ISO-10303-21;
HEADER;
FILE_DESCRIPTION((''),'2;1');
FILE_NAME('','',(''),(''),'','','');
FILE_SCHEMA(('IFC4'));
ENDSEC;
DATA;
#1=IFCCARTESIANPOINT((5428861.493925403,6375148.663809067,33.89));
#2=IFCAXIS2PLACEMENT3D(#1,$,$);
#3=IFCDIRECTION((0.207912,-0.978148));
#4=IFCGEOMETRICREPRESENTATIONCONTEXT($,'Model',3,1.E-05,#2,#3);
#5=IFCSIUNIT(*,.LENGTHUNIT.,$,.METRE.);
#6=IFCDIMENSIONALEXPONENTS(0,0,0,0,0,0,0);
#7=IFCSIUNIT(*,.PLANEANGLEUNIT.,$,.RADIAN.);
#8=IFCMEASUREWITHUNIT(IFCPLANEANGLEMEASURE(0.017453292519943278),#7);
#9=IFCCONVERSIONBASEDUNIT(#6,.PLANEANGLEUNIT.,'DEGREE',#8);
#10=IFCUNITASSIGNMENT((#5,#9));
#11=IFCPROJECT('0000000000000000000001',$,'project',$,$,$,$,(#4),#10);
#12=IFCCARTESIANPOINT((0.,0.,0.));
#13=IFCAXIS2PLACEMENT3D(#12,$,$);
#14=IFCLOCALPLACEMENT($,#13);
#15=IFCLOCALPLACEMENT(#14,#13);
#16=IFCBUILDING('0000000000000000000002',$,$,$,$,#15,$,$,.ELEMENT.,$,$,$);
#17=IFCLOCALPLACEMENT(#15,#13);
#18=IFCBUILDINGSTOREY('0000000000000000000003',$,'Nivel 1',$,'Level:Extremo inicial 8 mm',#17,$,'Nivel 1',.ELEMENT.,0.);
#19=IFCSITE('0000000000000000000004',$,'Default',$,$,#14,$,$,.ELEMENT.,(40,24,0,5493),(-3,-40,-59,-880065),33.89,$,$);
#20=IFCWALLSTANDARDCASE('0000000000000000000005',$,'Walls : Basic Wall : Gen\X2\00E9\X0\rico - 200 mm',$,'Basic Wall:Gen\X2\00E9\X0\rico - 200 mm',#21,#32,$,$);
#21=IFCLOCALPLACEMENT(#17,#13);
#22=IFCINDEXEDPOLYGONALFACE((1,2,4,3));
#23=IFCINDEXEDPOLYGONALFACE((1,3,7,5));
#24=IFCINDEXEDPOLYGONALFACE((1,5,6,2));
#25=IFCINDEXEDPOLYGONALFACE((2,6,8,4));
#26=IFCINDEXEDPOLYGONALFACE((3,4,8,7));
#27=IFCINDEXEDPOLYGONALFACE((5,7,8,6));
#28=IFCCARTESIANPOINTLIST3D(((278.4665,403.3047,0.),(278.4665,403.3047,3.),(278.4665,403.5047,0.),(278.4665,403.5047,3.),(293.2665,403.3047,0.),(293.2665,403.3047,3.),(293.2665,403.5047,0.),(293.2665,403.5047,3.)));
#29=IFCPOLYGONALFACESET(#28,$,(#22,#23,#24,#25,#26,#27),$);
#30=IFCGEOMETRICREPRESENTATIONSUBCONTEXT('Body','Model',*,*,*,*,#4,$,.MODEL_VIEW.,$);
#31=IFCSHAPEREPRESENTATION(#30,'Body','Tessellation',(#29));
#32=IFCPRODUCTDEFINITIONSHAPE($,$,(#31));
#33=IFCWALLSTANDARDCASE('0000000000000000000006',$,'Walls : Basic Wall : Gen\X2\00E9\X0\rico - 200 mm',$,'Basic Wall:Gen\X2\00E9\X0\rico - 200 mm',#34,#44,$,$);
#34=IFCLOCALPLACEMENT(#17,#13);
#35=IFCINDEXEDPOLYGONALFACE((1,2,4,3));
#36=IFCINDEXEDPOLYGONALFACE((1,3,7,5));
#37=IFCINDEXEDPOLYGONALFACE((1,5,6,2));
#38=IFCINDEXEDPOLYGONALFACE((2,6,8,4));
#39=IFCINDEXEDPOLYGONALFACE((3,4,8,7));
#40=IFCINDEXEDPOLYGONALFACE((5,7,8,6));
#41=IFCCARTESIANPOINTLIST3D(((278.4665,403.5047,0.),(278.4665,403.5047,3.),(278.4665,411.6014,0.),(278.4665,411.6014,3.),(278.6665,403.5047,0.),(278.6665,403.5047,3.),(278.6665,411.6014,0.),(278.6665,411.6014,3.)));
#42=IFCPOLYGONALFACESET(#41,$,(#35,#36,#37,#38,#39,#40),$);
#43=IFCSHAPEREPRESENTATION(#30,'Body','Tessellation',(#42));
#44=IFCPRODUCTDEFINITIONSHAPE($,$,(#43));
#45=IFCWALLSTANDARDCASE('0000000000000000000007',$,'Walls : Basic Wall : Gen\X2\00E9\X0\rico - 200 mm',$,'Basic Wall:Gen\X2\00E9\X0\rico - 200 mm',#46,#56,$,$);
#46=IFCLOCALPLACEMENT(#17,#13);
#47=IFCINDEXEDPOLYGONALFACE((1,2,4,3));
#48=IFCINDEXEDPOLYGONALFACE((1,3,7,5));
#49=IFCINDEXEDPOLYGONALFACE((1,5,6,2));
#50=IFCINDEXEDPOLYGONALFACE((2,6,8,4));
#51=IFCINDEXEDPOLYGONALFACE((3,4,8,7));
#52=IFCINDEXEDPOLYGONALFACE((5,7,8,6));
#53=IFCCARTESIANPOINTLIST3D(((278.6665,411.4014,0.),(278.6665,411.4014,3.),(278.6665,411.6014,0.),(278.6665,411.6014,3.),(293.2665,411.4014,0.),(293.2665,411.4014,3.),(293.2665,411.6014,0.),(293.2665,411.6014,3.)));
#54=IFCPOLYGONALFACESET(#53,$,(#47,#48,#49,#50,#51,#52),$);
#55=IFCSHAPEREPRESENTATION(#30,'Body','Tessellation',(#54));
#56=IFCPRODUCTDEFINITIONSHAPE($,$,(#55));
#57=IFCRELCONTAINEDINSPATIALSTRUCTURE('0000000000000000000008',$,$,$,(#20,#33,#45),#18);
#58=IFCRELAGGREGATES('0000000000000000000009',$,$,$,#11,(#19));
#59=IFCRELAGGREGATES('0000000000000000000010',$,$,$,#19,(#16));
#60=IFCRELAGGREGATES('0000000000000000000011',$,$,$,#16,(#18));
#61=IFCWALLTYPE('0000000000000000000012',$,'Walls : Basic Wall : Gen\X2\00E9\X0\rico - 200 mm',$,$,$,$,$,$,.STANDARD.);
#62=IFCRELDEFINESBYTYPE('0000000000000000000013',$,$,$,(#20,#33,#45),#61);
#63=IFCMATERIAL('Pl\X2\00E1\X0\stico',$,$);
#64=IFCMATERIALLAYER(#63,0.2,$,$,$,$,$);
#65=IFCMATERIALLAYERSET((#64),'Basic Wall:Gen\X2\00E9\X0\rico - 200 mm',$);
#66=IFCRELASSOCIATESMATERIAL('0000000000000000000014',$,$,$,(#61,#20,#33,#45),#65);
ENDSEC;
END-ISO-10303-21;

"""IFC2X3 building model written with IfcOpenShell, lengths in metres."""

from ifc_helpers import new_model, entity, si_unit, converted_unit, direction, frame, frame_2d, origin, place, context, subcontext, project, spatial, rectangle, extrude, material, layer, layer_set, layer_usage, type_object, element, save


model = new_model("IFC2X3")

# Units and contexts
model_context = context("Model", 3, precision=1e-05, world=frame((5428861.493925403, 6375148.663809067, 33.89)), true_north=direction((0.207912, -0.978148)))
body_context = subcontext(model_context, "Body", "Model", "MODEL_VIEW")
ifc_project = project(units=[si_unit("LENGTHUNIT", "METRE"), converted_unit("PLANEANGLEUNIT", "DEGREE", entity("IfcPlaneAngleMeasure", 0.017453292519943278), si_unit("PLANEANGLEUNIT", "RADIAN"), dimensions=[0, 0, 0, 0, 0, 0, 0])], contexts=[model_context])

# Site, building, storey
site_placement = place(None, origin())
site = spatial("IfcSite", under=ifc_project, at=site_placement, Name="Default", CompositionType="ELEMENT", RefLatitude=(40, 24, 0, 5493), RefLongitude=(-3, -40, -59, -880065), RefElevation=33.89)
building_placement = place(site_placement, origin())
building = spatial("IfcBuilding", under=site, at=building_placement, CompositionType="ELEMENT")
storey_placement = place(building_placement, origin())
storey = spatial("IfcBuildingStorey", under=building, at=storey_placement, Name="Nivel 1", ObjectType="Level:Extremo inicial 8 mm", LongName="Nivel 1", CompositionType="ELEMENT", Elevation=0.0)

# Walls
ifc_material_1 = material(Name="Plástico")
ifc_layer_1 = layer(ifc_material_1, 0.2)
ifc_layer_set_1 = layer_set([ifc_layer_1], Name="Basic Wall:Genérico - 200 mm")
wall_type = type_object("IfcWallType", Name="Walls : Basic Wall : Genérico - 200 mm", PredefinedType="STANDARD", material=ifc_layer_set_1)
ifc_layer_usage_1 = layer_usage(ifc_layer_set_1, "AXIS2", "NEGATIVE", 0.1)
wall_1_placement = place(storey_placement, frame((293.2665, 403.4047, 0.0), z_axis=(0.0, 0.0, 1.0), x_axis=(-1.0, 0.0, 0.0)))
element("IfcWallStandardCase", 1, at=wall_1_placement, inside=storey, type_object=wall_type, material=ifc_layer_usage_1, Name="Walls : Basic Wall : Genérico - 200 mm", ObjectType="Basic Wall:Genérico - 200 mm", context=body_context, shape_type="SweptSolid", body=[
    extrude(rectangle(XDim=14.8, YDim=0.2, at=frame_2d((7.4, 0.0), x_axis=(-1.0, 0.0))), origin(), (0.0, 0.0, 1.0), 3.0),
])
ifc_layer_usage_2 = layer_usage(ifc_layer_set_1, "AXIS2", "NEGATIVE", 0.1)
wall_2_placement = place(storey_placement, frame((278.5665, 403.5047, 0.0), z_axis=(0.0, 0.0, 1.0), x_axis=(0.0, 1.0, 0.0)))
element("IfcWallStandardCase", 2, at=wall_2_placement, inside=storey, type_object=wall_type, material=ifc_layer_usage_2, Name="Walls : Basic Wall : Genérico - 200 mm", ObjectType="Basic Wall:Genérico - 200 mm", context=body_context, shape_type="SweptSolid", body=[
    extrude(rectangle(XDim=8.0967, YDim=0.2, at=frame_2d((4.0484, 0.0), x_axis=(-1.0, 0.0))), origin(), (0.0, 0.0, 1.0), 3.0),
])
ifc_layer_usage_3 = layer_usage(ifc_layer_set_1, "AXIS2", "NEGATIVE", 0.1)
wall_3_placement = place(storey_placement, frame((278.6665, 411.5014, 0.0)))
element("IfcWallStandardCase", 3, at=wall_3_placement, inside=storey, type_object=wall_type, material=ifc_layer_usage_3, Name="Walls : Basic Wall : Genérico - 200 mm", ObjectType="Basic Wall:Genérico - 200 mm", context=body_context, shape_type="SweptSolid", body=[
    extrude(rectangle(XDim=14.6, YDim=0.2, at=frame_2d((7.3, 0.0), x_axis=(-1.0, 0.0))), origin(), (0.0, 0.0, 1.0), 3.0),
])

save(model, "model.ifc")
